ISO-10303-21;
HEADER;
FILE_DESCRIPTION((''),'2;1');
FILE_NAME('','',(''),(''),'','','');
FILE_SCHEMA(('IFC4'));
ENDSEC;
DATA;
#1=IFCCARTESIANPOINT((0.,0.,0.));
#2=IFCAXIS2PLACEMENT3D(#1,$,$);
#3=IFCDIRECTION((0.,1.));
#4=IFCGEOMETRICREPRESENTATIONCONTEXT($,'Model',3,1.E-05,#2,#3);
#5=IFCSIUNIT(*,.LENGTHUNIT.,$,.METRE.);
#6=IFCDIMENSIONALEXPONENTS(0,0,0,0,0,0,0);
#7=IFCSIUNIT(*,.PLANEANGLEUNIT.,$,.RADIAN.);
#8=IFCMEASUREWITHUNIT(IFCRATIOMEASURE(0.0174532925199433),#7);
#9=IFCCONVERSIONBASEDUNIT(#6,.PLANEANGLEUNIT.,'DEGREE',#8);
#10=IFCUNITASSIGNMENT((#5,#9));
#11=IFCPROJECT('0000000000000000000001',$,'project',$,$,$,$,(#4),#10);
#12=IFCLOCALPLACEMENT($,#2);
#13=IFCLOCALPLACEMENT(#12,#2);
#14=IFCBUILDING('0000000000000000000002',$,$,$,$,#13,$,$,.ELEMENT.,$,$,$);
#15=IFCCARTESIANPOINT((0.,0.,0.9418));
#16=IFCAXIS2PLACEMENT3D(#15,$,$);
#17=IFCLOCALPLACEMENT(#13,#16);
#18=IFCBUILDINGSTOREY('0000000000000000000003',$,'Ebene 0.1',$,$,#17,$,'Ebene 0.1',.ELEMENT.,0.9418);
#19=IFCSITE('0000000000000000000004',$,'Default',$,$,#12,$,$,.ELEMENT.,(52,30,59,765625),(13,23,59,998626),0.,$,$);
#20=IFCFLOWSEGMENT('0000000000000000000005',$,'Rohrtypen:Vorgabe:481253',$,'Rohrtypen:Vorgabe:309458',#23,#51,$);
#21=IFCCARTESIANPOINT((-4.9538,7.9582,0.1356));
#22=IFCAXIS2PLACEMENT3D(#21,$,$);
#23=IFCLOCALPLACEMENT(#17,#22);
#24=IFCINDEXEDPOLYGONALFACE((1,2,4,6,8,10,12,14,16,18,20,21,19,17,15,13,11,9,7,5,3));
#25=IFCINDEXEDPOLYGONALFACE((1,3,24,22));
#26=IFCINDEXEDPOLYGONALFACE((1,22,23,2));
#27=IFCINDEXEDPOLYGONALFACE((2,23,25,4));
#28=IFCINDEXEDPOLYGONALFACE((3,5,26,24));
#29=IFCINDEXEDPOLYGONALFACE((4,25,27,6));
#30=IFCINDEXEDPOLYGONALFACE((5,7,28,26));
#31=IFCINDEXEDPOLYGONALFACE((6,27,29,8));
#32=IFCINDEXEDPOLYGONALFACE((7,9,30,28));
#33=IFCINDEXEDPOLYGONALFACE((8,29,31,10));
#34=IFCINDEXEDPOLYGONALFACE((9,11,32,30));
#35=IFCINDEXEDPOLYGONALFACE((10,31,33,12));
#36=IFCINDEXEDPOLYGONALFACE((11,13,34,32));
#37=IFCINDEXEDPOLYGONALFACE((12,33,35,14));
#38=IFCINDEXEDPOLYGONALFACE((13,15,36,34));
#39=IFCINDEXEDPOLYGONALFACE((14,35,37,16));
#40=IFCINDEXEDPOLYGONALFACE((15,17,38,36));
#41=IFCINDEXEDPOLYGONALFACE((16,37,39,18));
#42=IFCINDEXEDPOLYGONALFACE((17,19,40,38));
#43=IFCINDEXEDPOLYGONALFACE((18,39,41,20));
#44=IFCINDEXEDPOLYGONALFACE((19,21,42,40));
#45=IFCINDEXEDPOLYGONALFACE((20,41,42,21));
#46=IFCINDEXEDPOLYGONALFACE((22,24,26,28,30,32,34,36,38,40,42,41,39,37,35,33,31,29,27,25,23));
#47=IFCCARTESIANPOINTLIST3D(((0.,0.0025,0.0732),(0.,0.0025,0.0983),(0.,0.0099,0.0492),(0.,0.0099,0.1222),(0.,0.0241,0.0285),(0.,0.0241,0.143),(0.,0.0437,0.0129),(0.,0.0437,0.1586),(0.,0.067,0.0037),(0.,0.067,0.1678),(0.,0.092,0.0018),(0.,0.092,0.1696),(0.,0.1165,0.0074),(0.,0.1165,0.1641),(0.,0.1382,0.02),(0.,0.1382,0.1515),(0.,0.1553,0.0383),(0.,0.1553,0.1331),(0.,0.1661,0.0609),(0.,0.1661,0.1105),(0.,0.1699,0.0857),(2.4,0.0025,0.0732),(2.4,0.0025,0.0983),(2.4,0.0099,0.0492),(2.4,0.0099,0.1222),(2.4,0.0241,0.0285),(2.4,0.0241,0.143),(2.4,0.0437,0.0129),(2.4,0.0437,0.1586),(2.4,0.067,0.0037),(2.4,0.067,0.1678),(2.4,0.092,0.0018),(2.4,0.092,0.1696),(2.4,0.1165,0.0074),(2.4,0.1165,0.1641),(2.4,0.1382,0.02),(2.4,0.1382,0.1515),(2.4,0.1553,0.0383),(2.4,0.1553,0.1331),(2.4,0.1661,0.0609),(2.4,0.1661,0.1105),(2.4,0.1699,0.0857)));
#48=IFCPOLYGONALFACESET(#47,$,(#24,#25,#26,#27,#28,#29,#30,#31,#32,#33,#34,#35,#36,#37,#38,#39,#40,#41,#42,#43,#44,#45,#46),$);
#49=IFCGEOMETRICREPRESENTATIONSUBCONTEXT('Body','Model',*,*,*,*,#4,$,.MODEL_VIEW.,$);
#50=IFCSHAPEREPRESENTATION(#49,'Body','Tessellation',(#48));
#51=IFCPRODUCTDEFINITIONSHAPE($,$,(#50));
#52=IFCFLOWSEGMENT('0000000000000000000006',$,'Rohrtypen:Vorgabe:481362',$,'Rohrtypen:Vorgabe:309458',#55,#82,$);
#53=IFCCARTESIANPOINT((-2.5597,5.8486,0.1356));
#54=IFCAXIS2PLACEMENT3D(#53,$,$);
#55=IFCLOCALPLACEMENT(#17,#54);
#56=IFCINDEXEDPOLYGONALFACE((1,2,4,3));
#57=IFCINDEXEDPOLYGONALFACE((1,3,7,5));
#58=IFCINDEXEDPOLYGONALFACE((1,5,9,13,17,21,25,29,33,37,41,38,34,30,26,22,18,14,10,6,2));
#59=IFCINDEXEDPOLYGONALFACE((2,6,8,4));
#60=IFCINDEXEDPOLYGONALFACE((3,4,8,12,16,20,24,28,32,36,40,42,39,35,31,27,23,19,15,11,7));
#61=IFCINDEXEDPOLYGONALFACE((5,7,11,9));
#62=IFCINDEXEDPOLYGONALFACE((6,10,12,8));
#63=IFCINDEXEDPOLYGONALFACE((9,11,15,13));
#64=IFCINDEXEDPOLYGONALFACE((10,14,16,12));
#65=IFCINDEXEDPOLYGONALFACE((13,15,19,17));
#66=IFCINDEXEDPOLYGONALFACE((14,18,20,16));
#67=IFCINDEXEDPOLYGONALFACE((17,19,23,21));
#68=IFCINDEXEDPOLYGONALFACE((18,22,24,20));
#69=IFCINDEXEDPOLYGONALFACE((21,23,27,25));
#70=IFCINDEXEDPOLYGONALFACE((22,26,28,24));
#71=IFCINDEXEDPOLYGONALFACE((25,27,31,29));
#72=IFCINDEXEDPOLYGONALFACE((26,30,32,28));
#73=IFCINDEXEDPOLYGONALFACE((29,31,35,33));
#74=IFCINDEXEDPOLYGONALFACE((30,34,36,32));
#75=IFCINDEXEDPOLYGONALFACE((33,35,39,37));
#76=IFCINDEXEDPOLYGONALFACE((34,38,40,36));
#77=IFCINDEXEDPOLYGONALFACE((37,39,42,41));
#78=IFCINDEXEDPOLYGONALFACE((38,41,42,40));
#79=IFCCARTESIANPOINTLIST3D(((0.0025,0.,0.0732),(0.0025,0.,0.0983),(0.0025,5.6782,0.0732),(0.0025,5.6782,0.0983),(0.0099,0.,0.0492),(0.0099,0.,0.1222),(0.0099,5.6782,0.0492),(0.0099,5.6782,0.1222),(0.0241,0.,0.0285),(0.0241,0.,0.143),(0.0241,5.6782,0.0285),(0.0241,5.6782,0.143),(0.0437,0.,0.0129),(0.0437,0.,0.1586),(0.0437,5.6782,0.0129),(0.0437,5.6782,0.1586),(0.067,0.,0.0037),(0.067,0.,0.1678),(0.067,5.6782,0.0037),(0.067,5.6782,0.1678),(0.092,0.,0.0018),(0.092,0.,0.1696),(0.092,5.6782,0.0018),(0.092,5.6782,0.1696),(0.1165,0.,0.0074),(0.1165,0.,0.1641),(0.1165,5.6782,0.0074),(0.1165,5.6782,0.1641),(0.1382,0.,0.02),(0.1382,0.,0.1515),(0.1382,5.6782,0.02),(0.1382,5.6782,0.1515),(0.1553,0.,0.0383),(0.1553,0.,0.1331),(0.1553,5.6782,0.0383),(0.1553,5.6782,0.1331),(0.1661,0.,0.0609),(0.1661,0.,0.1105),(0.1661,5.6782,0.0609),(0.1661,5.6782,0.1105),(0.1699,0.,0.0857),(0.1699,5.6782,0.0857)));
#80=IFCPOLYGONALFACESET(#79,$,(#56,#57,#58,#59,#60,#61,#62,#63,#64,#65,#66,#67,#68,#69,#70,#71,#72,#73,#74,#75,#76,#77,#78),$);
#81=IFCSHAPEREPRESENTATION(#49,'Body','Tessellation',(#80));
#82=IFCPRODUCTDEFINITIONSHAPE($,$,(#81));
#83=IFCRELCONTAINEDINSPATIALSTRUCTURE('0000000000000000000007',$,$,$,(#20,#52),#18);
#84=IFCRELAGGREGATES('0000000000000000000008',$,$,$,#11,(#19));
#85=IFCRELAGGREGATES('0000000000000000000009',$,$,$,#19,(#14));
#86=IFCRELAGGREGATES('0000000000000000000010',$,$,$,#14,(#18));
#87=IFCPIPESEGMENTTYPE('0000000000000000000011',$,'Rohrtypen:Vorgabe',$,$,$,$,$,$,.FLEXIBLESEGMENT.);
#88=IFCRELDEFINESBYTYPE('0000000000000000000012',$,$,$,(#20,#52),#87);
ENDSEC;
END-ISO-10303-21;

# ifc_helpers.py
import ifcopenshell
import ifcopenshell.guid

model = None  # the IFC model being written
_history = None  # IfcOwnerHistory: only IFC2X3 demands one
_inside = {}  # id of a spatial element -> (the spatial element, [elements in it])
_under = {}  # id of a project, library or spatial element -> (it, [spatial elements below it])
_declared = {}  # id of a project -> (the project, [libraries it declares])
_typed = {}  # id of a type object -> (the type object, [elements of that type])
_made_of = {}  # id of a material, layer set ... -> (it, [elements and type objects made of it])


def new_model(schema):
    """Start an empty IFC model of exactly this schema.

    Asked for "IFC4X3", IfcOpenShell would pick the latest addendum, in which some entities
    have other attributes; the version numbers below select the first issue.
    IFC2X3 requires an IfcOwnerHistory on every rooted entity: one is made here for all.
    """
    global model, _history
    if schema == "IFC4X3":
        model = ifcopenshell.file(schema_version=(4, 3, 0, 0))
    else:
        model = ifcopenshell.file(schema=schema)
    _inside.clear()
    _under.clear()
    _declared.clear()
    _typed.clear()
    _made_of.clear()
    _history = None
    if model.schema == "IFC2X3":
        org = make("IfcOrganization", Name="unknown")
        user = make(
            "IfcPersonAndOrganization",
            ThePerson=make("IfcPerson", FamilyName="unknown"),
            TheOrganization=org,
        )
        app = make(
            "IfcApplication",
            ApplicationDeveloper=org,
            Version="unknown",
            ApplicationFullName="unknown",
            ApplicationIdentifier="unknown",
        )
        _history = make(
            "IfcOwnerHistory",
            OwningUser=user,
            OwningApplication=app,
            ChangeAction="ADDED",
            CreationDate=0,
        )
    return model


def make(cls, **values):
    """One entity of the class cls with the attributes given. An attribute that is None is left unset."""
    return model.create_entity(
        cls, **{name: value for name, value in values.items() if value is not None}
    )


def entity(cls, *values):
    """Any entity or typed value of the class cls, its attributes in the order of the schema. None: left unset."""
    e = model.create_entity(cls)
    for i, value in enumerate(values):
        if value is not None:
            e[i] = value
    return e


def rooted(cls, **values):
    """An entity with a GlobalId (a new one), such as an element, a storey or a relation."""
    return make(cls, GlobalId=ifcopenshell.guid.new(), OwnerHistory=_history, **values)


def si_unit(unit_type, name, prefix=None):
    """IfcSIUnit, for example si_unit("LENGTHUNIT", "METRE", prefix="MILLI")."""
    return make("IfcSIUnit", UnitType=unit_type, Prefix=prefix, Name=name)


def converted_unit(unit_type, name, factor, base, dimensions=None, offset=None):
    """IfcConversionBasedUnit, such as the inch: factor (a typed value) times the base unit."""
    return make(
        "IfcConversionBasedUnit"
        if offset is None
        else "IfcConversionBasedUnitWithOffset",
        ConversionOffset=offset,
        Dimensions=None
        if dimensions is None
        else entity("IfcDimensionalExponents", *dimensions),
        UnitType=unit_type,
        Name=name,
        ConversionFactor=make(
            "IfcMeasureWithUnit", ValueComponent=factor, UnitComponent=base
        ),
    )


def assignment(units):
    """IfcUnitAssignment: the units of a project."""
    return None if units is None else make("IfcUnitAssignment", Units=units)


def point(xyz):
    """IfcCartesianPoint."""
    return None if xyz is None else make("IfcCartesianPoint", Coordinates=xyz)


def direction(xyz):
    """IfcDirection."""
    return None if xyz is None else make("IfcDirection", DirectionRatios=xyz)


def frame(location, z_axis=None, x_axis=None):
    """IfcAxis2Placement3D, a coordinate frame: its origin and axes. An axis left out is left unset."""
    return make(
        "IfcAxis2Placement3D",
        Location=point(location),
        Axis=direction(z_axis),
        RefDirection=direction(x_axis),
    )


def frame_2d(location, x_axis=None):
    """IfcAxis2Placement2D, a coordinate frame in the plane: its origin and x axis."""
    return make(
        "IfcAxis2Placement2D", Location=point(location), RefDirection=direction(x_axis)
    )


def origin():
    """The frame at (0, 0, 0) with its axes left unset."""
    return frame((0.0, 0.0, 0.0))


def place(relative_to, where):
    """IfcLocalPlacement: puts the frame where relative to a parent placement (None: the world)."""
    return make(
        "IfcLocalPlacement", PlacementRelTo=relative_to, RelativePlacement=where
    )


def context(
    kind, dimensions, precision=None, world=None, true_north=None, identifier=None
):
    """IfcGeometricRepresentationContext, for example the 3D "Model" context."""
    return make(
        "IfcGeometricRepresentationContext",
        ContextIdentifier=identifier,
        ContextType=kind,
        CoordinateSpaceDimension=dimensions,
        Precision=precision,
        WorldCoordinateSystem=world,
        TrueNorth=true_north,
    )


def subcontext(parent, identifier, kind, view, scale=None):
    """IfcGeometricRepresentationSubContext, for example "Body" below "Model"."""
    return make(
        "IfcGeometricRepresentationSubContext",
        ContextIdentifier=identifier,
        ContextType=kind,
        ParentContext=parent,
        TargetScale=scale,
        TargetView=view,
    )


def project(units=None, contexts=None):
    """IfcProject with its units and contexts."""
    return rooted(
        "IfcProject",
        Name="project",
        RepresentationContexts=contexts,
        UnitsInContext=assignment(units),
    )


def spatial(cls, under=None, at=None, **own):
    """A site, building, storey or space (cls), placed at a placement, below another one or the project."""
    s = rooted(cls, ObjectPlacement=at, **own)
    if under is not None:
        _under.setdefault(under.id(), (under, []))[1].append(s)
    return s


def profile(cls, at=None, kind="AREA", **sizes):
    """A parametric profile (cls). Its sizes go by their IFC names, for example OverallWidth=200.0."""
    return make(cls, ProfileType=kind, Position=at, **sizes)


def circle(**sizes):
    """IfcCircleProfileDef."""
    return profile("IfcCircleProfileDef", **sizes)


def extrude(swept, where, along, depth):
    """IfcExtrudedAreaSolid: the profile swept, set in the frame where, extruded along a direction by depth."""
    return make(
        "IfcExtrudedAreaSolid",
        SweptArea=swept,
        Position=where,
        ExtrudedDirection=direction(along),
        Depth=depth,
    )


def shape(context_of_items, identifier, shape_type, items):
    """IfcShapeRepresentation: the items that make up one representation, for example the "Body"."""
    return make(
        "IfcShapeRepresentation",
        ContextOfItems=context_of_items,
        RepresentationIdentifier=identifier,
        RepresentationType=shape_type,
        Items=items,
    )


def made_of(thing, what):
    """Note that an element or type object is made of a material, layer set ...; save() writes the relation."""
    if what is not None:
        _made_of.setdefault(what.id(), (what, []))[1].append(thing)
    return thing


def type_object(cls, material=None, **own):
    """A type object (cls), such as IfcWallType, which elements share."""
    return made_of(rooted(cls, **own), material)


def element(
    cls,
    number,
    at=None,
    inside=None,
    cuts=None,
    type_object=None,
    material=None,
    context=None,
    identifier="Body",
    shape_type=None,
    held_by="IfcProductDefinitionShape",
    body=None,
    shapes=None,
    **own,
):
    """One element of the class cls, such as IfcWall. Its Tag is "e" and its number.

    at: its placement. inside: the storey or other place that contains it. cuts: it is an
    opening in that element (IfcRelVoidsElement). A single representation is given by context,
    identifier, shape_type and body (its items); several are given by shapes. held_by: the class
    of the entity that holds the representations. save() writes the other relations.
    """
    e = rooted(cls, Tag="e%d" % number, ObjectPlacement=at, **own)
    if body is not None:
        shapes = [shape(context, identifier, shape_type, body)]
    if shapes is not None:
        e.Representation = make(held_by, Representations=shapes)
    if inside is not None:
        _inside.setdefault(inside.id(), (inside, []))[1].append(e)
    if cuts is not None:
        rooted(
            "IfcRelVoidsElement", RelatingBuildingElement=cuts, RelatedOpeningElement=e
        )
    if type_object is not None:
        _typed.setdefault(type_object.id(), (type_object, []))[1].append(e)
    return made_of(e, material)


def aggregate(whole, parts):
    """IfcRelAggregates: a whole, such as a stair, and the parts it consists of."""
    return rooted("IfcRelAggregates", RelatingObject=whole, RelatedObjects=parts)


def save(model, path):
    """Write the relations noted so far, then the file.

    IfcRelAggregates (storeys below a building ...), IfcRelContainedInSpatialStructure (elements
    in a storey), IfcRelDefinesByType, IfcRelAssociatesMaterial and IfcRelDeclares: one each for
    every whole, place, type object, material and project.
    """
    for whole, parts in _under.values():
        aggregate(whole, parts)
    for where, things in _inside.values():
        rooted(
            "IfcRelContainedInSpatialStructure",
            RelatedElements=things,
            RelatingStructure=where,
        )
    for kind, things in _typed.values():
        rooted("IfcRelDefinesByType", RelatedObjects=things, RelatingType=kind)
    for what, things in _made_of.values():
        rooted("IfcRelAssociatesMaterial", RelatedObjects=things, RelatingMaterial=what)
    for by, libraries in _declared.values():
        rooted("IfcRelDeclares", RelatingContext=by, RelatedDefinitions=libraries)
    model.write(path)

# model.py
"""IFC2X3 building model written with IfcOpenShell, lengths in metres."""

from ifc_helpers import new_model, entity, si_unit, converted_unit, direction, frame, frame_2d, origin, place, context, subcontext, project, spatial, circle, extrude, type_object, element, save


model = new_model("IFC2X3")

# Units and contexts
model_context = context("Model", 3, precision=1e-05, world=origin(), true_north=direction((0.0, 1.0)))
body_context = subcontext(model_context, "Body", "Model", "MODEL_VIEW")
ifc_project = project(units=[si_unit("LENGTHUNIT", "METRE"), converted_unit("PLANEANGLEUNIT", "DEGREE", entity("IfcRatioMeasure", 0.0174532925199433), si_unit("PLANEANGLEUNIT", "RADIAN"), dimensions=[0, 0, 0, 0, 0, 0, 0])], contexts=[model_context])

# Site, building, storey
site_placement = place(None, origin())
site = spatial("IfcSite", under=ifc_project, at=site_placement, Name="Default", CompositionType="ELEMENT", RefLatitude=(52, 30, 59, 765625), RefLongitude=(13, 23, 59, 998626), RefElevation=0.0)
building_placement = place(site_placement, origin())
building = spatial("IfcBuilding", under=site, at=building_placement, CompositionType="ELEMENT")
storey_placement = place(building_placement, frame((0.0, 0.0, 0.9418)))
storey = spatial("IfcBuildingStorey", under=building, at=storey_placement, Name="Ebene 0.1", LongName="Ebene 0.1", CompositionType="ELEMENT", Elevation=0.9418)

# Flow segments
pipe_segment_type = type_object("IfcPipeSegmentType", Name="Rohrtypen:Vorgabe", PredefinedType="FLEXIBLESEGMENT")
flow_segment_1_placement = place(storey_placement, frame((-4.9538, 7.9582, 0.1356)))
element("IfcFlowSegment", 1, at=flow_segment_1_placement, inside=storey, type_object=pipe_segment_type, Name="Rohrtypen:Vorgabe:481253", ObjectType="Rohrtypen:Vorgabe:309458", context=body_context, shape_type="SweptSolid", body=[
    extrude(circle(Radius=0.0841, at=frame_2d((0.0, 0.0), x_axis=(1.0, 0.0))), frame((0.0, 0.0857, 0.0857), z_axis=(1.0, 0.0, 0.0), x_axis=(0.0, 1.0, 0.0)), (0.0, 0.0, 1.0), 2.4),
])
flow_segment_2_placement = place(storey_placement, frame((-2.5597, 5.8486, 0.1356)))
element("IfcFlowSegment", 2, at=flow_segment_2_placement, inside=storey, type_object=pipe_segment_type, Name="Rohrtypen:Vorgabe:481362", ObjectType="Rohrtypen:Vorgabe:309458", context=body_context, shape_type="SweptSolid", body=[
    extrude(circle(Radius=0.0841, at=frame_2d((0.0, 0.0), x_axis=(1.0, 0.0))), frame((0.0857, 0.0, 0.0857), z_axis=(0.0, 1.0, 0.0), x_axis=(1.0, 0.0, 0.0)), (0.0, 0.0, 1.0), 5.6782),
])

save(model, "model.ifc")
